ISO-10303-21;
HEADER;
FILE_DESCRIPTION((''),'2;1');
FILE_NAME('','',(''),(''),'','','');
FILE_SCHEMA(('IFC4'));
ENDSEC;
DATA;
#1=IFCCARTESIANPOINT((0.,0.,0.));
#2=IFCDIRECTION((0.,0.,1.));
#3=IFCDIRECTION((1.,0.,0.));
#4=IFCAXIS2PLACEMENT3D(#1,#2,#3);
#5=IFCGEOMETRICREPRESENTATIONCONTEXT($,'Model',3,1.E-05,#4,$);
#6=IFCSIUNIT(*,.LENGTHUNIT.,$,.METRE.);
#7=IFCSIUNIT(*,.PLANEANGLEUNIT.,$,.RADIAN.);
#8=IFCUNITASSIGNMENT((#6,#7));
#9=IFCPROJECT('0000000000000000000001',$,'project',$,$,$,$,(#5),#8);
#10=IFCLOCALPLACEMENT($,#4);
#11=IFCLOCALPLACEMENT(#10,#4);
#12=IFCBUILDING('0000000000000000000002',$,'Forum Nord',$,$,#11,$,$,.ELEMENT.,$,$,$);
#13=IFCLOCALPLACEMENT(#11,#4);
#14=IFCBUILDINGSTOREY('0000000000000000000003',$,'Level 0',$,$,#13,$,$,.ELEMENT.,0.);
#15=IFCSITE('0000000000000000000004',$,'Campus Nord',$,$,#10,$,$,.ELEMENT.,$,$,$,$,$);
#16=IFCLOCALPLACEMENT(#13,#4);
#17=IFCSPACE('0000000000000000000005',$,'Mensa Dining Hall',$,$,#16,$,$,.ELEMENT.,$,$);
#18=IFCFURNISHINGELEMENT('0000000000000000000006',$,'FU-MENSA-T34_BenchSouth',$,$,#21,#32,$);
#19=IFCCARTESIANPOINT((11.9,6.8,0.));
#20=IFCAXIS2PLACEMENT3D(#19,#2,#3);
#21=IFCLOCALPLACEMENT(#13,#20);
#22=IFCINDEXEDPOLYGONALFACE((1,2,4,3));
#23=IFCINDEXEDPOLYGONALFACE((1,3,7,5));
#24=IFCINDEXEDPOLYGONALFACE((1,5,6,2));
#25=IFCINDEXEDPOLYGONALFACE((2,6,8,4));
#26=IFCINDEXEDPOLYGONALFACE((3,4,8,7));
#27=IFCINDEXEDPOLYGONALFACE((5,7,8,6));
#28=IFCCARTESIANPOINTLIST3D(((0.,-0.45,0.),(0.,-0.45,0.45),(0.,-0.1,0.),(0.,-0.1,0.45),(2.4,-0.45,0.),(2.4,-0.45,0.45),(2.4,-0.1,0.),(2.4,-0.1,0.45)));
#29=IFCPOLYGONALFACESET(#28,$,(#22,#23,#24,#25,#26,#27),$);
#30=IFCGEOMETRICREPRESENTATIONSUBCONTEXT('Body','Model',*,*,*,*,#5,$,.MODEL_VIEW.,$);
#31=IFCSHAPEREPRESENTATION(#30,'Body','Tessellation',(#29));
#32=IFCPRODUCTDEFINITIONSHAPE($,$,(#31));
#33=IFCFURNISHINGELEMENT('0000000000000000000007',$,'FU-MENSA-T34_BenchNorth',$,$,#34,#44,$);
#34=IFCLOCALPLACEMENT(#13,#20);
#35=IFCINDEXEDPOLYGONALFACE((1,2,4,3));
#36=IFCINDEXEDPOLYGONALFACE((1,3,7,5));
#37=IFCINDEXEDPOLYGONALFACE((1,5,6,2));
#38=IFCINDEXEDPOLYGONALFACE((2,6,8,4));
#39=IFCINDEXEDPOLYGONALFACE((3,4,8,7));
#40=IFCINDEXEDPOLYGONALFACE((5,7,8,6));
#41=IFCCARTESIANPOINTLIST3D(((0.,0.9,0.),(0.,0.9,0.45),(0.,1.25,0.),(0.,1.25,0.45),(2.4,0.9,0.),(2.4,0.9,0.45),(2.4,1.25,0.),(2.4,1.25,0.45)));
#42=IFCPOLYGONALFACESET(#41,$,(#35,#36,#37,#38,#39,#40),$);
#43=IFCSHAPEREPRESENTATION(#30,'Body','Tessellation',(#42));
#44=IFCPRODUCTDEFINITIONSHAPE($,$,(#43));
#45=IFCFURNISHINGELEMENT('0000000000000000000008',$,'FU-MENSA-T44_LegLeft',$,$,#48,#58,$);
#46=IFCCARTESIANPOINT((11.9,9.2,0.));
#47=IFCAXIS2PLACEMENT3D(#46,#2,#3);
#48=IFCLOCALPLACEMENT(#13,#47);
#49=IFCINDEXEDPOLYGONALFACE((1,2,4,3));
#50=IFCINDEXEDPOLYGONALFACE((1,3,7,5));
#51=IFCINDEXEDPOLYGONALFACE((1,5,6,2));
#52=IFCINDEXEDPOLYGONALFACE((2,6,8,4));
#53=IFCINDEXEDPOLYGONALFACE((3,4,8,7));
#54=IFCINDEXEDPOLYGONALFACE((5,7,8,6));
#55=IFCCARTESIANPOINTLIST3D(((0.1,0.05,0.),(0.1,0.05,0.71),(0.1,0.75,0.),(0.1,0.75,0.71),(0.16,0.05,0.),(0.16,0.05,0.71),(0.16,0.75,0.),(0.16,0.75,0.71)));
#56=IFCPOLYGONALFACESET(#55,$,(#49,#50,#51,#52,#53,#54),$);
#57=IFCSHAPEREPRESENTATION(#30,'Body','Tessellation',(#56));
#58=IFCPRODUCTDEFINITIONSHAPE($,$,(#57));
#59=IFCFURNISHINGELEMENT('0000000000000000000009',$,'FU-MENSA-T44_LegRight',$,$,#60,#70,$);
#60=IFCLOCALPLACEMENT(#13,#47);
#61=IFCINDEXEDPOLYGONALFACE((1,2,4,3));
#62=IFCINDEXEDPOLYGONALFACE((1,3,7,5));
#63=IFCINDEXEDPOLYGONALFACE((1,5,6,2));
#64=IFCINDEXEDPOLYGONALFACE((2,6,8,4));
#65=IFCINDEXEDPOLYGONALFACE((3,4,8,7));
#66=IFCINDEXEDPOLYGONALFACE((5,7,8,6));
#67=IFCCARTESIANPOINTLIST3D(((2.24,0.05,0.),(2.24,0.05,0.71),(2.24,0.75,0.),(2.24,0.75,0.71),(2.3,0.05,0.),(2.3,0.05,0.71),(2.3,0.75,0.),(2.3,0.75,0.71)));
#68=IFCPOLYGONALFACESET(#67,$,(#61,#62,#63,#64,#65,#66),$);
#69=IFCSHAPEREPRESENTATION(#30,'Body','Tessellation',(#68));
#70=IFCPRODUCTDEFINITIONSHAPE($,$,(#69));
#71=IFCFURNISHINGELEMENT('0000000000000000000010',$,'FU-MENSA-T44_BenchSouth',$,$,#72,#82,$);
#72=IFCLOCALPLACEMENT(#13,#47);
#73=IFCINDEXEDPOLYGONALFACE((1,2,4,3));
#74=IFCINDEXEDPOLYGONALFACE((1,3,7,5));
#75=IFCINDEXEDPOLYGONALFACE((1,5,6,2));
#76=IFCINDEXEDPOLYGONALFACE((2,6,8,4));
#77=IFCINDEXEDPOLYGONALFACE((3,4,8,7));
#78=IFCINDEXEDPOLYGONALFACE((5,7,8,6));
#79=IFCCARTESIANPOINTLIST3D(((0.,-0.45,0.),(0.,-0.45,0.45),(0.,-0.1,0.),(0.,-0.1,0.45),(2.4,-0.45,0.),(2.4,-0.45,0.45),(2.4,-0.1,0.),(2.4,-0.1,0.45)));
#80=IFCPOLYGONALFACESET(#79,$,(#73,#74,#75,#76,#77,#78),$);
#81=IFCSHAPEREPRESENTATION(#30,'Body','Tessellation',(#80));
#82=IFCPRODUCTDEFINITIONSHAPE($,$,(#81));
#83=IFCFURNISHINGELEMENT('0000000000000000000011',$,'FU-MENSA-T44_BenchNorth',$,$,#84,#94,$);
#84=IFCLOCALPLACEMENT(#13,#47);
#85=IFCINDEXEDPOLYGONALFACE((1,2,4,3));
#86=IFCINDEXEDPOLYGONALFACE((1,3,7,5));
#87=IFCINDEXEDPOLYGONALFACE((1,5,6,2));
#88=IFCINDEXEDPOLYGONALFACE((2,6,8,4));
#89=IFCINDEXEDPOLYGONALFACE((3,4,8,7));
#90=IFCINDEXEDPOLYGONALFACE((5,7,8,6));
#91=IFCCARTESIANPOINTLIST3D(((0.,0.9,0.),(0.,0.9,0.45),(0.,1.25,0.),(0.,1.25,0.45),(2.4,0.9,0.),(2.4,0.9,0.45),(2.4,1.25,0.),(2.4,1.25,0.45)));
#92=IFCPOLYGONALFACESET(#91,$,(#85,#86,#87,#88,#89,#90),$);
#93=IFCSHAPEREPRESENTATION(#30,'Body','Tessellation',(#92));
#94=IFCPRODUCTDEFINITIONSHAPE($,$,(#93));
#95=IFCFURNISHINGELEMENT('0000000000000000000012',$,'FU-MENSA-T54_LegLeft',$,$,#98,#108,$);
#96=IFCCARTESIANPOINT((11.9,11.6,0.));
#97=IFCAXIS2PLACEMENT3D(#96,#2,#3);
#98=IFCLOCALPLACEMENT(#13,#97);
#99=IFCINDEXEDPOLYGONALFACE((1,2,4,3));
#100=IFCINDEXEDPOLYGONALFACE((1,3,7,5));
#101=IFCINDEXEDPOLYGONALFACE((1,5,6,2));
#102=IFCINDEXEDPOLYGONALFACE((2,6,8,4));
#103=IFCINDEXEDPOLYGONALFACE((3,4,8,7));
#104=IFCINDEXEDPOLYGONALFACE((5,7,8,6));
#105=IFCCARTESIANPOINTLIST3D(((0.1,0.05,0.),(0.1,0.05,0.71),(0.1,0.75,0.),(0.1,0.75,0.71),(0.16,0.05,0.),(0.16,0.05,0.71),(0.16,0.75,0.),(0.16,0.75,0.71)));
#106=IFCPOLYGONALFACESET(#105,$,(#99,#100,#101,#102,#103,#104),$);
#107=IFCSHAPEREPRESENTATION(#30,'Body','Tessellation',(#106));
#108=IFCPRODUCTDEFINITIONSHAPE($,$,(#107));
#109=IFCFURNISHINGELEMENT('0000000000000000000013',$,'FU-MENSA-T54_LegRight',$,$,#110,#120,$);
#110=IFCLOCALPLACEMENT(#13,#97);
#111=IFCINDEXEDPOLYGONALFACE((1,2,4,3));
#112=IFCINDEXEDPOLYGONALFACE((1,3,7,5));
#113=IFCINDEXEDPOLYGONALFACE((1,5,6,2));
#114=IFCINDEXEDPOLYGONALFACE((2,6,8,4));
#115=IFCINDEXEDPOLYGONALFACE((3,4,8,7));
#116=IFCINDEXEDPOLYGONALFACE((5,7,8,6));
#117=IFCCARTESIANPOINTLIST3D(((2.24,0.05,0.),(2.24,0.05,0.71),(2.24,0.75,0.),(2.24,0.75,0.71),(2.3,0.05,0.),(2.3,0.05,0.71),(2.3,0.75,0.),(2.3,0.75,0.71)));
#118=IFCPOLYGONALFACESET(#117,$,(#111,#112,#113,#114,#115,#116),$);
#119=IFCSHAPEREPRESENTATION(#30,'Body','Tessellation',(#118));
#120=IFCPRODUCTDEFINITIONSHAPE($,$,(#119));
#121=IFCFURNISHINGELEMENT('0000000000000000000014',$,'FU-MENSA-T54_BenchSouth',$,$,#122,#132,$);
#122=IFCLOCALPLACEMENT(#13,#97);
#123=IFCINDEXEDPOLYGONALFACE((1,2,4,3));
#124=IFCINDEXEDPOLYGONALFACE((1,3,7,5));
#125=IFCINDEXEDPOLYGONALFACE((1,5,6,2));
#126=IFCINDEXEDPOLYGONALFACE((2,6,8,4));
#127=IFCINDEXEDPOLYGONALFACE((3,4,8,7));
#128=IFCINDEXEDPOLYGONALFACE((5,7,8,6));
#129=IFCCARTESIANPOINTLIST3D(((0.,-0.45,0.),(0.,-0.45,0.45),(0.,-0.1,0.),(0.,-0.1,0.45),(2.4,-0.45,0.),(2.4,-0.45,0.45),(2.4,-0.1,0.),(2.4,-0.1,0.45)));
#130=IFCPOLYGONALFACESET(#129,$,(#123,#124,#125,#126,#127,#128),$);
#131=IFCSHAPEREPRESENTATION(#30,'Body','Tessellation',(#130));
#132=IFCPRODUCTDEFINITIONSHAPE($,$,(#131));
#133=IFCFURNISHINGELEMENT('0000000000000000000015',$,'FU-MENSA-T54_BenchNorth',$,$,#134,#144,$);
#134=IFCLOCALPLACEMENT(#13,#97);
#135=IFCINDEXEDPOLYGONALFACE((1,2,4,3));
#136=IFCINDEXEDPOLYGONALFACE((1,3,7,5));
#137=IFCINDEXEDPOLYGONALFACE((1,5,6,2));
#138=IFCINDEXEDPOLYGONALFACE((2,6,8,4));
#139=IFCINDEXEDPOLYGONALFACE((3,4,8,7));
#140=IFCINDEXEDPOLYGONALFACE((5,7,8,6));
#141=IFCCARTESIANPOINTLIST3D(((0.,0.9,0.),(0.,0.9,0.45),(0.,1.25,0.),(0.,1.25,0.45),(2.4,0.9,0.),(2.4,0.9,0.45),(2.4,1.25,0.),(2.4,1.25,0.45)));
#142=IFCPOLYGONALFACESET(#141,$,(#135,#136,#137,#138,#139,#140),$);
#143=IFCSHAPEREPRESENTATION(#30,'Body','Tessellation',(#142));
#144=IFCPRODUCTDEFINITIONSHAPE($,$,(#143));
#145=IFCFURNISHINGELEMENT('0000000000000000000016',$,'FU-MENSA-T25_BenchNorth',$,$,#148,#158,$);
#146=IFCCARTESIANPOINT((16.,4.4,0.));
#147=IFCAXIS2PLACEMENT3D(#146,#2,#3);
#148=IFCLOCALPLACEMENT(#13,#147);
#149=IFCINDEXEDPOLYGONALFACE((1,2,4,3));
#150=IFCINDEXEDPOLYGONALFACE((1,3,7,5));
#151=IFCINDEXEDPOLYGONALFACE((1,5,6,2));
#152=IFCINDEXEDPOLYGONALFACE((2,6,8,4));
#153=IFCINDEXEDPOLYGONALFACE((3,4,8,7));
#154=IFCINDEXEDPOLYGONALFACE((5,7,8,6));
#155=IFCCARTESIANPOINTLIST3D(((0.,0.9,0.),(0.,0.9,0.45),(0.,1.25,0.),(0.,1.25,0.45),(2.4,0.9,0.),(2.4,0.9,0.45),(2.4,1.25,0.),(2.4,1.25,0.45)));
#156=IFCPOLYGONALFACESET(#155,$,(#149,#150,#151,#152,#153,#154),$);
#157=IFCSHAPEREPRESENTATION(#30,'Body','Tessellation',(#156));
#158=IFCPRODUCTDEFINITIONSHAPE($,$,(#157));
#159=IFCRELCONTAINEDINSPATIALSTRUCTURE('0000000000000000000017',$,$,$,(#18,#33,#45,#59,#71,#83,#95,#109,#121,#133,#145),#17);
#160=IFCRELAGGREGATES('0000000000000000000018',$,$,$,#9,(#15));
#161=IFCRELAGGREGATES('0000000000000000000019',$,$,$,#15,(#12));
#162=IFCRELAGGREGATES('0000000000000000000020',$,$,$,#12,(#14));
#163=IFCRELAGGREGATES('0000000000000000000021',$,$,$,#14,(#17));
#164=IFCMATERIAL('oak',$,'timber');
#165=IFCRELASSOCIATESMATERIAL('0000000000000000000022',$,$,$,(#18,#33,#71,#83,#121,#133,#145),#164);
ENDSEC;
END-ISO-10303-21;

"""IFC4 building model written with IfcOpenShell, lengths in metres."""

from ifc_helpers import new_model, si_unit, frame, frame_2d, origin_with_axes, place, context, subcontext, project, spatial, rectangle, extrude, material, element, save


model = new_model("IFC4")

# Units and contexts
model_context = context("Model", 3, precision=1e-05, world=origin_with_axes())
body_context = subcontext(model_context, "Body", "Model", "MODEL_VIEW")
ifc_project = project(units=[si_unit("LENGTHUNIT", "METRE"), si_unit("PLANEANGLEUNIT", "RADIAN")], contexts=[model_context])

# Site, building, storey
site_placement = place(None, origin_with_axes())
site = spatial("IfcSite", under=ifc_project, at=site_placement, Name="Campus Nord", CompositionType="ELEMENT")
building_placement = place(site_placement, origin_with_axes())
building = spatial("IfcBuilding", under=site, at=building_placement, Name="Forum Nord", CompositionType="ELEMENT")
storey_placement = place(building_placement, origin_with_axes())
storey = spatial("IfcBuildingStorey", under=building, at=storey_placement, Name="Level 0", CompositionType="ELEMENT", Elevation=0.0)

# Shared definitions
space_placement = place(storey_placement, origin_with_axes())
space = spatial("IfcSpace", under=storey, at=space_placement, Name="Mensa Dining Hall", CompositionType="ELEMENT")

# Furnishing elements
ifc_material_1 = material(Name="oak", Category="timber")
furnishing_1_placement = place(storey_placement, frame((11.9, 6.8, 0.0), z_axis=(0.0, 0.0, 1.0), x_axis=(1.0, 0.0, 0.0)))
element("IfcFurnishingElement", 1, at=furnishing_1_placement, inside=space, material=ifc_material_1, Name="FU-MENSA-T34_BenchSouth", context=body_context, shape_type="SweptSolid", body=[
    extrude(rectangle(XDim=2.4, YDim=0.35, at=frame_2d((1.2, -0.275), x_axis=(1.0, 0.0))), origin_with_axes(), (0.0, 0.0, 1.0), 0.45),
])
furnishing_2_placement = place(storey_placement, frame((11.9, 6.8, 0.0), z_axis=(0.0, 0.0, 1.0), x_axis=(1.0, 0.0, 0.0)))
element("IfcFurnishingElement", 2, at=furnishing_2_placement, inside=space, material=ifc_material_1, Name="FU-MENSA-T34_BenchNorth", context=body_context, shape_type="SweptSolid", body=[
    extrude(rectangle(XDim=2.4, YDim=0.35, at=frame_2d((1.2, 1.075), x_axis=(1.0, 0.0))), origin_with_axes(), (0.0, 0.0, 1.0), 0.45),
])
furnishing_3_placement = place(storey_placement, frame((11.9, 9.2, 0.0), z_axis=(0.0, 0.0, 1.0), x_axis=(1.0, 0.0, 0.0)))
element("IfcFurnishingElement", 3, at=furnishing_3_placement, inside=space, Name="FU-MENSA-T44_LegLeft", context=body_context, shape_type="SweptSolid", body=[
    extrude(rectangle(XDim=0.06, YDim=0.7, at=frame_2d((0.13, 0.4), x_axis=(1.0, 0.0))), origin_with_axes(), (0.0, 0.0, 1.0), 0.71),
])
furnishing_4_placement = place(storey_placement, frame((11.9, 9.2, 0.0), z_axis=(0.0, 0.0, 1.0), x_axis=(1.0, 0.0, 0.0)))
element("IfcFurnishingElement", 4, at=furnishing_4_placement, inside=space, Name="FU-MENSA-T44_LegRight", context=body_context, shape_type="SweptSolid", body=[
    extrude(rectangle(XDim=0.06, YDim=0.7, at=frame_2d((2.27, 0.4), x_axis=(1.0, 0.0))), origin_with_axes(), (0.0, 0.0, 1.0), 0.71),
])
furnishing_5_placement = place(storey_placement, frame((11.9, 9.2, 0.0), z_axis=(0.0, 0.0, 1.0), x_axis=(1.0, 0.0, 0.0)))
element("IfcFurnishingElement", 5, at=furnishing_5_placement, inside=space, material=ifc_material_1, Name="FU-MENSA-T44_BenchSouth", context=body_context, shape_type="SweptSolid", body=[
    extrude(rectangle(XDim=2.4, YDim=0.35, at=frame_2d((1.2, -0.275), x_axis=(1.0, 0.0))), origin_with_axes(), (0.0, 0.0, 1.0), 0.45),
])
furnishing_6_placement = place(storey_placement, frame((11.9, 9.2, 0.0), z_axis=(0.0, 0.0, 1.0), x_axis=(1.0, 0.0, 0.0)))
element("IfcFurnishingElement", 6, at=furnishing_6_placement, inside=space, material=ifc_material_1, Name="FU-MENSA-T44_BenchNorth", context=body_context, shape_type="SweptSolid", body=[
    extrude(rectangle(XDim=2.4, YDim=0.35, at=frame_2d((1.2, 1.075), x_axis=(1.0, 0.0))), origin_with_axes(), (0.0, 0.0, 1.0), 0.45),
])
furnishing_7_placement = place(storey_placement, frame((11.9, 11.6, 0.0), z_axis=(0.0, 0.0, 1.0), x_axis=(1.0, 0.0, 0.0)))
element("IfcFurnishingElement", 7, at=furnishing_7_placement, inside=space, Name="FU-MENSA-T54_LegLeft", context=body_context, shape_type="SweptSolid", body=[
    extrude(rectangle(XDim=0.06, YDim=0.7, at=frame_2d((0.13, 0.4), x_axis=(1.0, 0.0))), origin_with_axes(), (0.0, 0.0, 1.0), 0.71),
])
furnishing_8_placement = place(storey_placement, frame((11.9, 11.6, 0.0), z_axis=(0.0, 0.0, 1.0), x_axis=(1.0, 0.0, 0.0)))
element("IfcFurnishingElement", 8, at=furnishing_8_placement, inside=space, Name="FU-MENSA-T54_LegRight", context=body_context, shape_type="SweptSolid", body=[
    extrude(rectangle(XDim=0.06, YDim=0.7, at=frame_2d((2.27, 0.4), x_axis=(1.0, 0.0))), origin_with_axes(), (0.0, 0.0, 1.0), 0.71),
])
furnishing_9_placement = place(storey_placement, frame((11.9, 11.6, 0.0), z_axis=(0.0, 0.0, 1.0), x_axis=(1.0, 0.0, 0.0)))
element("IfcFurnishingElement", 9, at=furnishing_9_placement, inside=space, material=ifc_material_1, Name="FU-MENSA-T54_BenchSouth", context=body_context, shape_type="SweptSolid", body=[
    extrude(rectangle(XDim=2.4, YDim=0.35, at=frame_2d((1.2, -0.275), x_axis=(1.0, 0.0))), origin_with_axes(), (0.0, 0.0, 1.0), 0.45),
])
for number, where, z_axis, x_axis, name in (
    (10, (11.9, 11.6, 0.0), (0.0, 0.0, 1.0), (1.0, 0.0, 0.0), "FU-MENSA-T54_BenchNorth"),
    (11, (16.0, 4.4, 0.0), (0.0, 0.0, 1.0), (1.0, 0.0, 0.0), "FU-MENSA-T25_BenchNorth"),
):
    element("IfcFurnishingElement", number, at=place(storey_placement, frame(where, z_axis=z_axis, x_axis=x_axis)), inside=space, material=ifc_material_1, Name=name, context=body_context, shape_type="SweptSolid", body=[
        extrude(rectangle(XDim=2.4, YDim=0.35, at=frame_2d((1.2, 1.075), x_axis=(1.0, 0.0))), origin_with_axes(), (0.0, 0.0, 1.0), 0.45),
    ])

save(model, "model.ifc")
